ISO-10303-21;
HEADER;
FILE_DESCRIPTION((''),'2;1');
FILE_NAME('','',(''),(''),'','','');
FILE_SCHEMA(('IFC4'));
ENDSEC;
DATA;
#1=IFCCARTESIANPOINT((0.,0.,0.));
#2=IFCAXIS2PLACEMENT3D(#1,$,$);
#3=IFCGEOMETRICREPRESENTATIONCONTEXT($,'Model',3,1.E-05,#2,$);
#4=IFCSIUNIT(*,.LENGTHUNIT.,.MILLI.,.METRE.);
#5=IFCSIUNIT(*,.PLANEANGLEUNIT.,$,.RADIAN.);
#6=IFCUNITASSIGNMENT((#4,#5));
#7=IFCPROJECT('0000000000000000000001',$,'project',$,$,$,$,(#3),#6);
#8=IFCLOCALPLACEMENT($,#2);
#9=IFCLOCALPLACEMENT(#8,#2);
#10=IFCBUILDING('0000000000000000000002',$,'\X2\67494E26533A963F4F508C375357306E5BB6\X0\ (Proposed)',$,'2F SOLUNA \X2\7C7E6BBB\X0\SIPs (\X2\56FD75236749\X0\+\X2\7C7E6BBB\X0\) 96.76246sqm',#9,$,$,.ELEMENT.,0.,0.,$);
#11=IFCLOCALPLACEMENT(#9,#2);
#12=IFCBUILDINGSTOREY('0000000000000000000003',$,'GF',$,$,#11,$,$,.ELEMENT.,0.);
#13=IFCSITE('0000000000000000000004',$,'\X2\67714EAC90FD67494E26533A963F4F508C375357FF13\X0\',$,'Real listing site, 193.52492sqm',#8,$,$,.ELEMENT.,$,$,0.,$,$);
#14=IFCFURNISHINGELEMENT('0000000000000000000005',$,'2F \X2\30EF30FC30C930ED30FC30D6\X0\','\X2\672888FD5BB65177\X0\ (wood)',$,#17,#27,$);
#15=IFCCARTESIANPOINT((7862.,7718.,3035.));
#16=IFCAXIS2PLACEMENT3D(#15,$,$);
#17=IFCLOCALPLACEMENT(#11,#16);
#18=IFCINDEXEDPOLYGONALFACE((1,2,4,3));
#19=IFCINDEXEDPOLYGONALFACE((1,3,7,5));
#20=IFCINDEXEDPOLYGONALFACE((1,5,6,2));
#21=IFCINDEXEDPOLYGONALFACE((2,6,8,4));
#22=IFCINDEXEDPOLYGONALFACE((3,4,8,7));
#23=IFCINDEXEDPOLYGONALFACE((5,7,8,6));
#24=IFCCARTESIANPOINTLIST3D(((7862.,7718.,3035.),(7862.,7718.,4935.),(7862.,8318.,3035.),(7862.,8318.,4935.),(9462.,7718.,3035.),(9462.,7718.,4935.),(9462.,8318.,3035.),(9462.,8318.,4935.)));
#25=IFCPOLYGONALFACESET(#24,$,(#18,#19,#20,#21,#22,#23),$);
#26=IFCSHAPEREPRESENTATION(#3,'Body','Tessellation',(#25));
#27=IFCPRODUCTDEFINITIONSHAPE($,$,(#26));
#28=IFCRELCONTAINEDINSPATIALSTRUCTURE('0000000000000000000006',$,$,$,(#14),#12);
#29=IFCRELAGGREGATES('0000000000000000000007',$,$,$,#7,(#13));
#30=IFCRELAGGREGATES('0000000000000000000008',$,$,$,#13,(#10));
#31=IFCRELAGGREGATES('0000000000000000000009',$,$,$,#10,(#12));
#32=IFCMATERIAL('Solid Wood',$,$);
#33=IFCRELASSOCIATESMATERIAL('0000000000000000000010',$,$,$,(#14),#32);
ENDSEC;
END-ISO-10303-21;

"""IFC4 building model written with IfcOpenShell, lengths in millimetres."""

from ifc_helpers import new_model, si_unit, frame, frame_2d, origin, place, context, project, spatial, rectangle, extrude, material, element, save


model = new_model("IFC4")

# Units and contexts
model_context = context("Model", 3, precision=1e-05, world=origin())
ifc_project = project(units=[si_unit("LENGTHUNIT", "METRE", prefix="MILLI"), si_unit("PLANEANGLEUNIT", "RADIAN")], contexts=[model_context])

# Site, building, storey
site_placement = place(None, origin())
site = spatial("IfcSite", under=ifc_project, at=site_placement, Name="東京都杉並区阿佐谷南３", ObjectType="Real listing site, 193.52492sqm", CompositionType="ELEMENT", RefElevation=0.0)
building_placement = place(site_placement, origin())
building = spatial("IfcBuilding", under=site, at=building_placement, Name="杉並区阿佐谷南の家 (Proposed)", ObjectType="2F SOLUNA 籾殻SIPs (国産杉+籾殻) 96.76246sqm", CompositionType="ELEMENT", ElevationOfRefHeight=0.0, ElevationOfTerrain=0.0)
storey_placement = place(building_placement, origin())
storey = spatial("IfcBuildingStorey", under=building, at=storey_placement, Name="GF", CompositionType="ELEMENT", Elevation=0.0)

# Shared definitions
ifc_material_1 = material(Name="Solid Wood")

# Furnishing element
furnishing_1_placement = place(storey_placement, frame((7862.0, 7718.0, 3035.0)))
element("IfcFurnishingElement", 1, at=furnishing_1_placement, inside=storey, material=ifc_material_1, Name="2F ワードローブ", Description="木製家具 (wood)", context=model_context, shape_type="SweptSolid", body=[
    extrude(rectangle(XDim=1600.0, YDim=600.0, at=frame_2d((800.0, 300.0))), frame((7862.0, 7718.0, 3035.0)), (0.0, 0.0, 1.0), 1900.0),
])

save(model, "model.ifc")
